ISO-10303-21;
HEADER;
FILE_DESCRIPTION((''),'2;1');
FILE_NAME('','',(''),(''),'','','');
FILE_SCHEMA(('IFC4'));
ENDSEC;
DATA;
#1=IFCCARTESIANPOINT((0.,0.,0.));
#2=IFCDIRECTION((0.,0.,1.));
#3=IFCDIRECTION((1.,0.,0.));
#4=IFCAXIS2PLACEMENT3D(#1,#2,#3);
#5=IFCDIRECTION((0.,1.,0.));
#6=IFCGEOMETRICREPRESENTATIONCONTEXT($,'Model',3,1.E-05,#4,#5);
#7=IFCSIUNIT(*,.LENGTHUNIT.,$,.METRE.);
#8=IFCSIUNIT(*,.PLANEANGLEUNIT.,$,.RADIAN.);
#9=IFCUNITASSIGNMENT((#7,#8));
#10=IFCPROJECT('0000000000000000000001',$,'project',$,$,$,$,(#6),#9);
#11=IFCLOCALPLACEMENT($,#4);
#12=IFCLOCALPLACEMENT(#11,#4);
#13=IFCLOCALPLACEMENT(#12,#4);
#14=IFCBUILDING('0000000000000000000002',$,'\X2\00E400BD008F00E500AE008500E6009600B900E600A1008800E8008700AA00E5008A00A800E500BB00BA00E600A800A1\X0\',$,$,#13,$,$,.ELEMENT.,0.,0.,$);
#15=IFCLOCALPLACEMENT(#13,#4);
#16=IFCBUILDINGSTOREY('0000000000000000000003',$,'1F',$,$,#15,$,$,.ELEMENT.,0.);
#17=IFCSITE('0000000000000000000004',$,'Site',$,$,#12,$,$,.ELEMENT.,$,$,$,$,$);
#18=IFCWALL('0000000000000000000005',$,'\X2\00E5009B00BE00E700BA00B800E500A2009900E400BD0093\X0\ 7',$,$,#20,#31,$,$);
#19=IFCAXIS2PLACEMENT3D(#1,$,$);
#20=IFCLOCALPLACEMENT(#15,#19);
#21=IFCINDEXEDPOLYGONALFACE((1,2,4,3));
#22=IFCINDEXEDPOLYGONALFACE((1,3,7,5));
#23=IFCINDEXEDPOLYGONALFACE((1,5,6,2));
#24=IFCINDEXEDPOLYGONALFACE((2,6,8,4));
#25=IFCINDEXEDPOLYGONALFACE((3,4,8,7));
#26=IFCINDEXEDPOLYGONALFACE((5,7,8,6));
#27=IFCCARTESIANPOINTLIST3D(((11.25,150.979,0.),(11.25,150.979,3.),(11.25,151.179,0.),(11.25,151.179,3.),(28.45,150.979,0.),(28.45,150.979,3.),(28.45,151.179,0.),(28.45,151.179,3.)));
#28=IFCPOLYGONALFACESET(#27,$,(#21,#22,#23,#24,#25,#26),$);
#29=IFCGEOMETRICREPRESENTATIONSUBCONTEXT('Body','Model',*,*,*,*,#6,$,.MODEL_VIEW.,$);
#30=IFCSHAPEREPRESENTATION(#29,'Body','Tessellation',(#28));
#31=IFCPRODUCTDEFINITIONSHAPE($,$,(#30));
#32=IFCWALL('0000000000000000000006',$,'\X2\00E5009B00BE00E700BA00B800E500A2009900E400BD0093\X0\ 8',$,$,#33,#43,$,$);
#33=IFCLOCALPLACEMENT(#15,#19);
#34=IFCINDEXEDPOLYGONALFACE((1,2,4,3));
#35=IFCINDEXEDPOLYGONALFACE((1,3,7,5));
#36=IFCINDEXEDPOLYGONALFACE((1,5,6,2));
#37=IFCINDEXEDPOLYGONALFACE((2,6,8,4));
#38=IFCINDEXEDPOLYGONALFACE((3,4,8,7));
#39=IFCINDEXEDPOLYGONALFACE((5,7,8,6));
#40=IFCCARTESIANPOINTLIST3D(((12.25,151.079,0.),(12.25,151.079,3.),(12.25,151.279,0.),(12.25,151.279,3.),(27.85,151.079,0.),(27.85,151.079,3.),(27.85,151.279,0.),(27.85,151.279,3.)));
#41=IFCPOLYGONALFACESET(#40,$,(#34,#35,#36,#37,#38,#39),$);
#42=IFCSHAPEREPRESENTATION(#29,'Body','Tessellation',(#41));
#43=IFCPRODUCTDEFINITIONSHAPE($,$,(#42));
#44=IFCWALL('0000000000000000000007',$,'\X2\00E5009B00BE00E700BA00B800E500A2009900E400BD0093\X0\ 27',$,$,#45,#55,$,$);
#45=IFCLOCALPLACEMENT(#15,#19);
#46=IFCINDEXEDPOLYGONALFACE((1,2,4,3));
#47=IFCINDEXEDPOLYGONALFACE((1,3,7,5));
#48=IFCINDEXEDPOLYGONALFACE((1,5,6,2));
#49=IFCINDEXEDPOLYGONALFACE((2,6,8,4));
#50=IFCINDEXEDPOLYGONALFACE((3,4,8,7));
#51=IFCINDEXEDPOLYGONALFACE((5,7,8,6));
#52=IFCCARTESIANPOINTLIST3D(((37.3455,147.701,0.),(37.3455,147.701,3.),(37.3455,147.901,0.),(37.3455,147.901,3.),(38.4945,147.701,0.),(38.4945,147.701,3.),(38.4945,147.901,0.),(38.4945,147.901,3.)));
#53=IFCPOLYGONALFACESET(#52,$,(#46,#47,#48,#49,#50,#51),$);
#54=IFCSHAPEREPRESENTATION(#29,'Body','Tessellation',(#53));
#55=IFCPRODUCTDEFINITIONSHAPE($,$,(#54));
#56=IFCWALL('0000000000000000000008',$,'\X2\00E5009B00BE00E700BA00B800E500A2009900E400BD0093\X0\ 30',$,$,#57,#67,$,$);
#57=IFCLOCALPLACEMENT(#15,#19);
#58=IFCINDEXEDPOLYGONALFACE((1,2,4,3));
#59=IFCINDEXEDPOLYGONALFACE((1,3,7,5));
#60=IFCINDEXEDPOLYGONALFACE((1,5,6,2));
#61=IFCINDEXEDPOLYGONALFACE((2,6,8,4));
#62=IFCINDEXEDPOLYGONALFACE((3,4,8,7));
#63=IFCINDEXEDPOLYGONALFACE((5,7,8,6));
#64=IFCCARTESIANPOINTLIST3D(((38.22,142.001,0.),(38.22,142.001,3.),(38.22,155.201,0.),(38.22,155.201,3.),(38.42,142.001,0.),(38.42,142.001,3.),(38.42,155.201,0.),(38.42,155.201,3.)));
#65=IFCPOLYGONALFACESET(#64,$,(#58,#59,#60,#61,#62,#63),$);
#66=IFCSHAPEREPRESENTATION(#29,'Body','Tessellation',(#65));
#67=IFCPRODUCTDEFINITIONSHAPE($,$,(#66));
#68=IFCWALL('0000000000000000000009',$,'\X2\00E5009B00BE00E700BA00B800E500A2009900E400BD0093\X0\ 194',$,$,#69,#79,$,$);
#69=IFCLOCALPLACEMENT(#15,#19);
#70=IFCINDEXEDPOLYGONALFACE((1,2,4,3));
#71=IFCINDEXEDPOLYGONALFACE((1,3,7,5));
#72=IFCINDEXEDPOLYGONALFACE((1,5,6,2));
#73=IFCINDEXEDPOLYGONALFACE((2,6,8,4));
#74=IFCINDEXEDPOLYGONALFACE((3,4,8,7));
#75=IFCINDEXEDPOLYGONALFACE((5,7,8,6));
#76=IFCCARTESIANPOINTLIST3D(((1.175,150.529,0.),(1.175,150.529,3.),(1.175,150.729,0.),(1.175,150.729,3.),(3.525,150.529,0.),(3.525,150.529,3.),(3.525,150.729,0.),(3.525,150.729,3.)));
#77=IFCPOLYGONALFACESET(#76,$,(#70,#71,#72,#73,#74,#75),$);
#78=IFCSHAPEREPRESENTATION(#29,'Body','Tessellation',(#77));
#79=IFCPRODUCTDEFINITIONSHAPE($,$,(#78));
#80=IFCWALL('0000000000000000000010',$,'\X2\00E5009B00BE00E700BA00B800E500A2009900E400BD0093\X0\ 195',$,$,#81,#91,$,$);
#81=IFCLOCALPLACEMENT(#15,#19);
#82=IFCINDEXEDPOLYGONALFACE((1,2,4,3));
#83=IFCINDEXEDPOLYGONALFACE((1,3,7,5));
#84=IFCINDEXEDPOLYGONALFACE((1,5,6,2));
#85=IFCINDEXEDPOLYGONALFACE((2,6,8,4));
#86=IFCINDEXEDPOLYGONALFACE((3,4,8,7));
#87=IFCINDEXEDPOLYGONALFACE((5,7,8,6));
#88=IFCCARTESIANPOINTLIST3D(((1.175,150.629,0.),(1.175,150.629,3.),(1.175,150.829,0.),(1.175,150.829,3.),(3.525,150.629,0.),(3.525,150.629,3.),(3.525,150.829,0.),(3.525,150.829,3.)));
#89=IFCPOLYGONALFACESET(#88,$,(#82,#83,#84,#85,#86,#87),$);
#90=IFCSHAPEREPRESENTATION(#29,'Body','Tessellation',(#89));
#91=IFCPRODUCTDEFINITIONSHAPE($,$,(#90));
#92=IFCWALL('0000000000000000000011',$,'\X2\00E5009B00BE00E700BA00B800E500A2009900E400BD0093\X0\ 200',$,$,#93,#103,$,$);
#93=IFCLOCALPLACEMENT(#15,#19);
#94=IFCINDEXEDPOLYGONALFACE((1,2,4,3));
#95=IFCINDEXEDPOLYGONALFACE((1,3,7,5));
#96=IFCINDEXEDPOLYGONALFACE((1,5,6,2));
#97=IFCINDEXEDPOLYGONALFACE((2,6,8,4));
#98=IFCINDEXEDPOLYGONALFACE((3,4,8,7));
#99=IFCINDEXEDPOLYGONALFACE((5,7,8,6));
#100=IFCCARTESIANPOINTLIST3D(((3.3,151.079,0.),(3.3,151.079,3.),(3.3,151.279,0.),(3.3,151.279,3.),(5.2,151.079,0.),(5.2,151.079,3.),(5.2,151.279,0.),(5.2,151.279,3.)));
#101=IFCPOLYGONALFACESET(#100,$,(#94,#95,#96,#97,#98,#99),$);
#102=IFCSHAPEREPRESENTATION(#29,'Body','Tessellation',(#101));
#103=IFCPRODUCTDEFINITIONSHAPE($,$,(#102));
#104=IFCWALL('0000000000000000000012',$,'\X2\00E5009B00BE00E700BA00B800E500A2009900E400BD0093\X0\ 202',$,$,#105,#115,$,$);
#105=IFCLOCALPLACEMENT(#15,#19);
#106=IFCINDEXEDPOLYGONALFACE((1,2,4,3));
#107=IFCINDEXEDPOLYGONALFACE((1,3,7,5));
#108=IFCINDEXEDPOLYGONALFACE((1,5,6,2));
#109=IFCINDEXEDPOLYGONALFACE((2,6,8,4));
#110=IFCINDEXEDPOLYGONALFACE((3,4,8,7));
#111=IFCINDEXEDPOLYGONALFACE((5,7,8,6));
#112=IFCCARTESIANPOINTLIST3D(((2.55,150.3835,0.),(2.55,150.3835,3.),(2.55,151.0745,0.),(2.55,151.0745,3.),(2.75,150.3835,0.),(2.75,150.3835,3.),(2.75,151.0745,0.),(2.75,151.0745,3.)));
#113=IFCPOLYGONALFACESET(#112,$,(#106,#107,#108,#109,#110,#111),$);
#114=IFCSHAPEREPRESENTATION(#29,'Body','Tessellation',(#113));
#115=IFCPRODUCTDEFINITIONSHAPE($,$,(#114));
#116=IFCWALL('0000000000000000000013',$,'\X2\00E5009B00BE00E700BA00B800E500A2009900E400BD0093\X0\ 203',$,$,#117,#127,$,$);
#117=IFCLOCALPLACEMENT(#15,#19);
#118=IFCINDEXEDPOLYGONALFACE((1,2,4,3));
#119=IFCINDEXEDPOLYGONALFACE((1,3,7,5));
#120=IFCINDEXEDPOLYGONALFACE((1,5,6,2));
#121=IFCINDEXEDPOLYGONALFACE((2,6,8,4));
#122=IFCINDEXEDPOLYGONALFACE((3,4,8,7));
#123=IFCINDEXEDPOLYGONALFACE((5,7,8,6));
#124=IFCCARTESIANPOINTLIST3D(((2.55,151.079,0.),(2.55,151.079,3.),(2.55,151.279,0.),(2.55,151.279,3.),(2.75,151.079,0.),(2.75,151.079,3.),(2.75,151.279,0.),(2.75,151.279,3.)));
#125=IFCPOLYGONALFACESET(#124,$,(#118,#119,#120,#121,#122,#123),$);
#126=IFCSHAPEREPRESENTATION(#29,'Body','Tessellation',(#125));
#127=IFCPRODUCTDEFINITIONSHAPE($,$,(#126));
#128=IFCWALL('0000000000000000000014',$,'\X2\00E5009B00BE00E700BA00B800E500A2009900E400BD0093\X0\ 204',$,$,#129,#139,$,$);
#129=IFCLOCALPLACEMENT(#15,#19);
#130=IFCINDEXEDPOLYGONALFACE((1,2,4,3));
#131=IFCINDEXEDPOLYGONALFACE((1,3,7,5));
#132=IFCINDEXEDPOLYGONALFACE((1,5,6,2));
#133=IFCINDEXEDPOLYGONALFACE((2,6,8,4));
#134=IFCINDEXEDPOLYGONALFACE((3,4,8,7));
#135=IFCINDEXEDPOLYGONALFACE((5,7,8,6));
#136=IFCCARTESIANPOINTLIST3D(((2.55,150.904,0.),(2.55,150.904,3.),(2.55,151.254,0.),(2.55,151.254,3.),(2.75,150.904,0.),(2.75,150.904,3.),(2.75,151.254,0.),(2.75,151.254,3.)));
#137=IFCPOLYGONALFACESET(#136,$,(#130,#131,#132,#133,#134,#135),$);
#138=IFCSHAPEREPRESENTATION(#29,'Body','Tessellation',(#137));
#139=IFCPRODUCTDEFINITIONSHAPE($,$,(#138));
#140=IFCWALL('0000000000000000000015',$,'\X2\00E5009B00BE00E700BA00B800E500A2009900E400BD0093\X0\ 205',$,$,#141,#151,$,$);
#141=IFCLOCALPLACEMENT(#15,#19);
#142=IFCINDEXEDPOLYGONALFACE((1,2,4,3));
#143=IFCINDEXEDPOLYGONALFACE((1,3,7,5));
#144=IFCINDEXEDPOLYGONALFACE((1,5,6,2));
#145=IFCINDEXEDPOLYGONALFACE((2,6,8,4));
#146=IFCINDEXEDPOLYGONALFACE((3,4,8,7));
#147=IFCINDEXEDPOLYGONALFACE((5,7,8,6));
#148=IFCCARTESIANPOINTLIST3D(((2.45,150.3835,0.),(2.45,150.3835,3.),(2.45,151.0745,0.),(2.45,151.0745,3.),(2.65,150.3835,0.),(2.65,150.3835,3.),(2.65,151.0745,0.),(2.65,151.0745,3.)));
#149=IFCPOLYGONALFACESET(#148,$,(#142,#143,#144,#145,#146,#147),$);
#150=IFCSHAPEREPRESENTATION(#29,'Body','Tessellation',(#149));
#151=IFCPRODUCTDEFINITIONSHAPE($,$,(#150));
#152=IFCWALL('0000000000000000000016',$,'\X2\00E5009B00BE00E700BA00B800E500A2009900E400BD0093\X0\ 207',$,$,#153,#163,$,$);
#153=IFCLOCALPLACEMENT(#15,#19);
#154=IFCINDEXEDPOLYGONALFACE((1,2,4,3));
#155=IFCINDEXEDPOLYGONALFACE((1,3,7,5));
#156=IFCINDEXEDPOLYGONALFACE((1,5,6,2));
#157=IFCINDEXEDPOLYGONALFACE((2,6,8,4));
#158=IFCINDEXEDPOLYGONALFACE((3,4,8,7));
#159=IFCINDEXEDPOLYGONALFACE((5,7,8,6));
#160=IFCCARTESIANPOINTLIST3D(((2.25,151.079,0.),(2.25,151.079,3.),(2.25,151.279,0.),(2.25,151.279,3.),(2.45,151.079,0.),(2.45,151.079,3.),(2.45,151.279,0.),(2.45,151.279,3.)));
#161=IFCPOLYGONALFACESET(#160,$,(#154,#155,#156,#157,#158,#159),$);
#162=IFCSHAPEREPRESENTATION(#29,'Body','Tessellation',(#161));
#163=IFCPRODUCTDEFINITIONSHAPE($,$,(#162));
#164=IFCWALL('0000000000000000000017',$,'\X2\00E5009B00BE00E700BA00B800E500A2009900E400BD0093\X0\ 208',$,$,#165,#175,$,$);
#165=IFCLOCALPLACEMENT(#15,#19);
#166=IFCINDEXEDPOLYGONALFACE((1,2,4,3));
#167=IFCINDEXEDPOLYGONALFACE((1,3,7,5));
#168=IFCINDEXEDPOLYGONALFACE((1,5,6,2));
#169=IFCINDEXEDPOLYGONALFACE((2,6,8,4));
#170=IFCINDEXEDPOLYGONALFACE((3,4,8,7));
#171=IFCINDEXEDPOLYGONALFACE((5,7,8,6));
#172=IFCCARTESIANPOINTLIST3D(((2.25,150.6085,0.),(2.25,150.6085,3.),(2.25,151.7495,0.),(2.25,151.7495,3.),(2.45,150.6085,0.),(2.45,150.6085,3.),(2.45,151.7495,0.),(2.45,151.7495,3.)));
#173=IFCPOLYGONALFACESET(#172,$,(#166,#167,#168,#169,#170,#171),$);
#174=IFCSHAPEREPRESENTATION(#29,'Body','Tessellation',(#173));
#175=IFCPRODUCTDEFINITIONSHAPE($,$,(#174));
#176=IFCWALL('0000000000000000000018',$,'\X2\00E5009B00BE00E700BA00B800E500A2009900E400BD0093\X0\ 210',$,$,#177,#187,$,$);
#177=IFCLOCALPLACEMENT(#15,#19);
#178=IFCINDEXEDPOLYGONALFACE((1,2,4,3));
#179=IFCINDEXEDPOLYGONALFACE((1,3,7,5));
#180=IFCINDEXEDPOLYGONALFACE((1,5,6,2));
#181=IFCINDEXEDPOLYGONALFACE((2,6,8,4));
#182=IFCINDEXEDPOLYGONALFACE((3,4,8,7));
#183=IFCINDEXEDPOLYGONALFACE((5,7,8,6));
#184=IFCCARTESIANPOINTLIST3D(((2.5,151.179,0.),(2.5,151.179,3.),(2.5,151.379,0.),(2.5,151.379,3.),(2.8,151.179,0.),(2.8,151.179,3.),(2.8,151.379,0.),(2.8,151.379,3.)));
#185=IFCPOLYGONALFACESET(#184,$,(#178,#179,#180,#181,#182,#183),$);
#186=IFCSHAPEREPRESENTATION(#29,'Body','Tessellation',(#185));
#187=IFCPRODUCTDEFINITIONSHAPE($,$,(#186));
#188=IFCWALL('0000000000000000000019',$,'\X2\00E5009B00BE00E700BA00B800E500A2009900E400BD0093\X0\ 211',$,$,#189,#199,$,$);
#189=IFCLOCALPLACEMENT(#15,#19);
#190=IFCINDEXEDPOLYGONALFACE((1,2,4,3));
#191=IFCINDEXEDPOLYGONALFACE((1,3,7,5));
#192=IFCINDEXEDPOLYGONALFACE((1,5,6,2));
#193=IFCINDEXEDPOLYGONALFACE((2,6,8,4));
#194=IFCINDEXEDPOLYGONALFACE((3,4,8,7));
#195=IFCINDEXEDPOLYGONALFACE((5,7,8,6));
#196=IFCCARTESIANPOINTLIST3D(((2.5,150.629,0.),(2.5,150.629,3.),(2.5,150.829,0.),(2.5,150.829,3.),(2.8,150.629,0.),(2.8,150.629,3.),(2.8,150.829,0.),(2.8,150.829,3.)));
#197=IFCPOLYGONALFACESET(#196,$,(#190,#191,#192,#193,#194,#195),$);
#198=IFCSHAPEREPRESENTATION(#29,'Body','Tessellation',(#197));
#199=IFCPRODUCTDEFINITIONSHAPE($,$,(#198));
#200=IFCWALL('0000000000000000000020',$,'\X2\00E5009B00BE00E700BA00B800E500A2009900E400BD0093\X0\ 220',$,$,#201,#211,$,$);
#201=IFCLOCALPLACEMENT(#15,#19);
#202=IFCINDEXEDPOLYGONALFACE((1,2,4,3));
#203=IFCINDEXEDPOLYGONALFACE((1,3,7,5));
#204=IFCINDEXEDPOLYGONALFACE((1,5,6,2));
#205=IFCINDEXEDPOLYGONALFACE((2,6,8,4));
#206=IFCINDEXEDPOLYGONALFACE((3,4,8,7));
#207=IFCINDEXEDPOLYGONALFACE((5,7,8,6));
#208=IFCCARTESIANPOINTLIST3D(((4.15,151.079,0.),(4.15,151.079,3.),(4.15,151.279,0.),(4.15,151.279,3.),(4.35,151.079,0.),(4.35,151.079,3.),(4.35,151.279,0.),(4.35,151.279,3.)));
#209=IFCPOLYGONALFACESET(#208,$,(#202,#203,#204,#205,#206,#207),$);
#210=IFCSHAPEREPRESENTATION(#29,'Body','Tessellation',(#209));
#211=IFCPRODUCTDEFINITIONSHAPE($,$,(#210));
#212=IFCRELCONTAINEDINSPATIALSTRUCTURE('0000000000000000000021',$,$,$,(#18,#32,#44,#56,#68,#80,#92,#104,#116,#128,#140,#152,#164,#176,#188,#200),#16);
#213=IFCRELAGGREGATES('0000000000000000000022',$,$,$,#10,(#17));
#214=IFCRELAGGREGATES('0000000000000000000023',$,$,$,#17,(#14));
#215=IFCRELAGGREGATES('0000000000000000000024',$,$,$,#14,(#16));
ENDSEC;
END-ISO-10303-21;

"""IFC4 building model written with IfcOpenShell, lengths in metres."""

from ifc_helpers import new_model, si_unit, direction, frame, frame_2d, origin_with_axes, place, context, subcontext, project, spatial, rectangle, extrude, element, save


model = new_model("IFC4")

# Units and contexts
model_context = context("Model", 3, precision=1e-05, world=origin_with_axes(), true_north=direction((0.0, 1.0, 0.0)))
body_context = subcontext(model_context, "Body", "Model", "MODEL_VIEW")
ifc_project = project(units=[si_unit("LENGTHUNIT", "METRE"), si_unit("PLANEANGLEUNIT", "RADIAN")], contexts=[model_context])

# Site, building, storey
placement = place(None, origin_with_axes())
site_placement = place(placement, origin_with_axes())
site = spatial("IfcSite", under=ifc_project, at=site_placement, Name="Site", CompositionType="ELEMENT")
building_placement = place(site_placement, origin_with_axes())
building = spatial("IfcBuilding", under=site, at=building_placement, Name="ä½\u008få®\u0085æ\u0096¹æ¡\u0088è\u0087ªå\u008a¨å»ºæ¨¡", CompositionType="ELEMENT", ElevationOfRefHeight=0.0, ElevationOfTerrain=0.0)
storey_placement = place(building_placement, origin_with_axes())
storey = spatial("IfcBuildingStorey", under=building, at=storey_placement, Name="1F", CompositionType="ELEMENT", Elevation=0.0)

# Walls
wall_1_placement = place(storey_placement, frame((19.85, 151.079, 0.0), z_axis=(0.0, 0.0, 1.0), x_axis=(-1.0, 0.0, 0.0)))
element("IfcWall", 1, at=wall_1_placement, inside=storey, Name="å\u009b¾çº¸å¢\u0099ä½\u0093 7", context=body_context, shape_type="SweptSolid", body=[
    extrude(rectangle(XDim=17.2, YDim=0.2, at=frame_2d((0.0, 0.0), x_axis=(1.0, 0.0, 0.0))), frame((0.0, 0.0, 0.0), z_axis=(0.0, 0.0, 1.0)), (0.0, 0.0, 1.0), 3.0),
])
wall_2_placement = place(storey_placement, frame((20.05, 151.179, 0.0), z_axis=(0.0, 0.0, 1.0), x_axis=(-1.0, 0.0, 0.0)))
element("IfcWall", 2, at=wall_2_placement, inside=storey, Name="å\u009b¾çº¸å¢\u0099ä½\u0093 8", context=body_context, shape_type="SweptSolid", body=[
    extrude(rectangle(XDim=15.6, YDim=0.2, at=frame_2d((0.0, 0.0), x_axis=(1.0, 0.0, 0.0))), frame((0.0, 0.0, 0.0), z_axis=(0.0, 0.0, 1.0)), (0.0, 0.0, 1.0), 3.0),
])
wall_3_placement = place(storey_placement, frame((37.92, 147.801, 0.0), z_axis=(0.0, 0.0, 1.0), x_axis=(-1.0, 0.0, 0.0)))
element("IfcWall", 3, at=wall_3_placement, inside=storey, Name="å\u009b¾çº¸å¢\u0099ä½\u0093 27", context=body_context, shape_type="SweptSolid", body=[
    extrude(rectangle(XDim=1.149, YDim=0.2, at=frame_2d((0.0, 0.0), x_axis=(1.0, 0.0, 0.0))), frame((0.0, 0.0, 0.0), z_axis=(0.0, 0.0, 1.0)), (0.0, 0.0, 1.0), 3.0),
])
wall_4_placement = place(storey_placement, frame((38.32, 148.601, 0.0), z_axis=(0.0, 0.0, 1.0), x_axis=(0.0, 1.0, 0.0)))
element("IfcWall", 4, at=wall_4_placement, inside=storey, Name="å\u009b¾çº¸å¢\u0099ä½\u0093 30", context=body_context, shape_type="SweptSolid", body=[
    extrude(rectangle(XDim=13.2, YDim=0.2, at=frame_2d((0.0, 0.0), x_axis=(1.0, 0.0, 0.0))), frame((0.0, 0.0, 0.0), z_axis=(0.0, 0.0, 1.0)), (0.0, 0.0, 1.0), 3.0),
])
for number, where, z_axis, x_axis, name in (
    (5, (2.35, 150.629, 0.0), (0.0, 0.0, 1.0), (-1.0, 0.0, 0.0), "å\u009b¾çº¸å¢\u0099ä½\u0093 194"),
    (6, (2.35, 150.729, 0.0), (0.0, 0.0, 1.0), (-1.0, 0.0, 0.0), "å\u009b¾çº¸å¢\u0099ä½\u0093 195"),
):
    element("IfcWall", number, at=place(storey_placement, frame(where, z_axis=z_axis, x_axis=x_axis)), inside=storey, Name=name, context=body_context, shape_type="SweptSolid", body=[
        extrude(rectangle(XDim=2.35, YDim=0.2, at=frame_2d((0.0, 0.0), x_axis=(1.0, 0.0, 0.0))), frame((0.0, 0.0, 0.0), z_axis=(0.0, 0.0, 1.0)), (0.0, 0.0, 1.0), 3.0),
    ])
wall_5_placement = place(storey_placement, frame((4.25, 151.179, 0.0), z_axis=(0.0, 0.0, 1.0), x_axis=(-1.0, 0.0, 0.0)))
element("IfcWall", 7, at=wall_5_placement, inside=storey, Name="å\u009b¾çº¸å¢\u0099ä½\u0093 200", context=body_context, shape_type="SweptSolid", body=[
    extrude(rectangle(XDim=1.9, YDim=0.2, at=frame_2d((0.0, 0.0), x_axis=(1.0, 0.0, 0.0))), frame((0.0, 0.0, 0.0), z_axis=(0.0, 0.0, 1.0)), (0.0, 0.0, 1.0), 3.0),
])
wall_6_placement = place(storey_placement, frame((2.65, 150.729, 0.0), z_axis=(0.0, 0.0, 1.0), x_axis=(0.0, -1.0, 0.0)))
element("IfcWall", 8, at=wall_6_placement, inside=storey, Name="å\u009b¾çº¸å¢\u0099ä½\u0093 202", context=body_context, shape_type="SweptSolid", body=[
    extrude(rectangle(XDim=0.691, YDim=0.2, at=frame_2d((0.0, 0.0), x_axis=(1.0, 0.0, 0.0))), frame((0.0, 0.0, 0.0), z_axis=(0.0, 0.0, 1.0)), (0.0, 0.0, 1.0), 3.0),
])
wall_7_placement = place(storey_placement, frame((2.65, 151.179, 0.0), z_axis=(0.0, 0.0, 1.0), x_axis=(0.0, 1.0, 0.0)))
element("IfcWall", 9, at=wall_7_placement, inside=storey, Name="å\u009b¾çº¸å¢\u0099ä½\u0093 203", context=body_context, shape_type="SweptSolid", body=[
    extrude(rectangle(XDim=0.2, YDim=0.2, at=frame_2d((0.0, 0.0), x_axis=(1.0, 0.0, 0.0))), frame((0.0, 0.0, 0.0), z_axis=(0.0, 0.0, 1.0)), (0.0, 0.0, 1.0), 3.0),
])
wall_8_placement = place(storey_placement, frame((2.65, 151.079, 0.0), z_axis=(0.0, 0.0, 1.0), x_axis=(0.0, -1.0, 0.0)))
element("IfcWall", 10, at=wall_8_placement, inside=storey, Name="å\u009b¾çº¸å¢\u0099ä½\u0093 204", context=body_context, shape_type="SweptSolid", body=[
    extrude(rectangle(XDim=0.35, YDim=0.2, at=frame_2d((0.0, 0.0), x_axis=(1.0, 0.0, 0.0))), frame((0.0, 0.0, 0.0), z_axis=(0.0, 0.0, 1.0)), (0.0, 0.0, 1.0), 3.0),
])
wall_9_placement = place(storey_placement, frame((2.55, 150.729, 0.0), z_axis=(0.0, 0.0, 1.0), x_axis=(0.0, -1.0, 0.0)))
element("IfcWall", 11, at=wall_9_placement, inside=storey, Name="å\u009b¾çº¸å¢\u0099ä½\u0093 205", context=body_context, shape_type="SweptSolid", body=[
    extrude(rectangle(XDim=0.691, YDim=0.2, at=frame_2d((0.0, 0.0), x_axis=(1.0, 0.0, 0.0))), frame((0.0, 0.0, 0.0), z_axis=(0.0, 0.0, 1.0)), (0.0, 0.0, 1.0), 3.0),
])
wall_10_placement = place(storey_placement, frame((2.35, 151.179, 0.0), z_axis=(0.0, 0.0, 1.0), x_axis=(0.0, 1.0, 0.0)))
element("IfcWall", 12, at=wall_10_placement, inside=storey, Name="å\u009b¾çº¸å¢\u0099ä½\u0093 207", context=body_context, shape_type="SweptSolid", body=[
    extrude(rectangle(XDim=0.2, YDim=0.2, at=frame_2d((0.0, 0.0), x_axis=(1.0, 0.0, 0.0))), frame((0.0, 0.0, 0.0), z_axis=(0.0, 0.0, 1.0)), (0.0, 0.0, 1.0), 3.0),
])
wall_11_placement = place(storey_placement, frame((2.35, 151.179, 0.0), z_axis=(0.0, 0.0, 1.0), x_axis=(0.0, -1.0, 0.0)))
element("IfcWall", 13, at=wall_11_placement, inside=storey, Name="å\u009b¾çº¸å¢\u0099ä½\u0093 208", context=body_context, shape_type="SweptSolid", body=[
    extrude(rectangle(XDim=1.141, YDim=0.2, at=frame_2d((0.0, 0.0), x_axis=(1.0, 0.0, 0.0))), frame((0.0, 0.0, 0.0), z_axis=(0.0, 0.0, 1.0)), (0.0, 0.0, 1.0), 3.0),
])
for number, where, z_axis, x_axis, name in (
    (14, (2.65, 151.279, 0.0), (0.0, 0.0, 1.0), (-1.0, 0.0, 0.0), "å\u009b¾çº¸å¢\u0099ä½\u0093 210"),
    (15, (2.65, 150.729, 0.0), (0.0, 0.0, 1.0), (-1.0, 0.0, 0.0), "å\u009b¾çº¸å¢\u0099ä½\u0093 211"),
):
    element("IfcWall", number, at=place(storey_placement, frame(where, z_axis=z_axis, x_axis=x_axis)), inside=storey, Name=name, context=body_context, shape_type="SweptSolid", body=[
        extrude(rectangle(XDim=0.3, YDim=0.2, at=frame_2d((0.0, 0.0), x_axis=(1.0, 0.0, 0.0))), frame((0.0, 0.0, 0.0), z_axis=(0.0, 0.0, 1.0)), (0.0, 0.0, 1.0), 3.0),
    ])
for number, where, z_axis, x_axis, name in (
    (16, (4.25, 151.179, 0.0), (0.0, 0.0, 1.0), (1.0, 0.0, 0.0), "å\u009b¾çº¸å¢\u0099ä½\u0093 220"),
):
    element("IfcWall", number, at=place(storey_placement, frame(where, z_axis=z_axis, x_axis=x_axis)), inside=storey, Name=name, context=body_context, shape_type="SweptSolid", body=[
        extrude(rectangle(XDim=0.2, YDim=0.2, at=frame_2d((0.0, 0.0), x_axis=(1.0, 0.0, 0.0))), frame((0.0, 0.0, 0.0), z_axis=(0.0, 0.0, 1.0)), (0.0, 0.0, 1.0), 3.0),
    ])

save(model, "model.ifc")
